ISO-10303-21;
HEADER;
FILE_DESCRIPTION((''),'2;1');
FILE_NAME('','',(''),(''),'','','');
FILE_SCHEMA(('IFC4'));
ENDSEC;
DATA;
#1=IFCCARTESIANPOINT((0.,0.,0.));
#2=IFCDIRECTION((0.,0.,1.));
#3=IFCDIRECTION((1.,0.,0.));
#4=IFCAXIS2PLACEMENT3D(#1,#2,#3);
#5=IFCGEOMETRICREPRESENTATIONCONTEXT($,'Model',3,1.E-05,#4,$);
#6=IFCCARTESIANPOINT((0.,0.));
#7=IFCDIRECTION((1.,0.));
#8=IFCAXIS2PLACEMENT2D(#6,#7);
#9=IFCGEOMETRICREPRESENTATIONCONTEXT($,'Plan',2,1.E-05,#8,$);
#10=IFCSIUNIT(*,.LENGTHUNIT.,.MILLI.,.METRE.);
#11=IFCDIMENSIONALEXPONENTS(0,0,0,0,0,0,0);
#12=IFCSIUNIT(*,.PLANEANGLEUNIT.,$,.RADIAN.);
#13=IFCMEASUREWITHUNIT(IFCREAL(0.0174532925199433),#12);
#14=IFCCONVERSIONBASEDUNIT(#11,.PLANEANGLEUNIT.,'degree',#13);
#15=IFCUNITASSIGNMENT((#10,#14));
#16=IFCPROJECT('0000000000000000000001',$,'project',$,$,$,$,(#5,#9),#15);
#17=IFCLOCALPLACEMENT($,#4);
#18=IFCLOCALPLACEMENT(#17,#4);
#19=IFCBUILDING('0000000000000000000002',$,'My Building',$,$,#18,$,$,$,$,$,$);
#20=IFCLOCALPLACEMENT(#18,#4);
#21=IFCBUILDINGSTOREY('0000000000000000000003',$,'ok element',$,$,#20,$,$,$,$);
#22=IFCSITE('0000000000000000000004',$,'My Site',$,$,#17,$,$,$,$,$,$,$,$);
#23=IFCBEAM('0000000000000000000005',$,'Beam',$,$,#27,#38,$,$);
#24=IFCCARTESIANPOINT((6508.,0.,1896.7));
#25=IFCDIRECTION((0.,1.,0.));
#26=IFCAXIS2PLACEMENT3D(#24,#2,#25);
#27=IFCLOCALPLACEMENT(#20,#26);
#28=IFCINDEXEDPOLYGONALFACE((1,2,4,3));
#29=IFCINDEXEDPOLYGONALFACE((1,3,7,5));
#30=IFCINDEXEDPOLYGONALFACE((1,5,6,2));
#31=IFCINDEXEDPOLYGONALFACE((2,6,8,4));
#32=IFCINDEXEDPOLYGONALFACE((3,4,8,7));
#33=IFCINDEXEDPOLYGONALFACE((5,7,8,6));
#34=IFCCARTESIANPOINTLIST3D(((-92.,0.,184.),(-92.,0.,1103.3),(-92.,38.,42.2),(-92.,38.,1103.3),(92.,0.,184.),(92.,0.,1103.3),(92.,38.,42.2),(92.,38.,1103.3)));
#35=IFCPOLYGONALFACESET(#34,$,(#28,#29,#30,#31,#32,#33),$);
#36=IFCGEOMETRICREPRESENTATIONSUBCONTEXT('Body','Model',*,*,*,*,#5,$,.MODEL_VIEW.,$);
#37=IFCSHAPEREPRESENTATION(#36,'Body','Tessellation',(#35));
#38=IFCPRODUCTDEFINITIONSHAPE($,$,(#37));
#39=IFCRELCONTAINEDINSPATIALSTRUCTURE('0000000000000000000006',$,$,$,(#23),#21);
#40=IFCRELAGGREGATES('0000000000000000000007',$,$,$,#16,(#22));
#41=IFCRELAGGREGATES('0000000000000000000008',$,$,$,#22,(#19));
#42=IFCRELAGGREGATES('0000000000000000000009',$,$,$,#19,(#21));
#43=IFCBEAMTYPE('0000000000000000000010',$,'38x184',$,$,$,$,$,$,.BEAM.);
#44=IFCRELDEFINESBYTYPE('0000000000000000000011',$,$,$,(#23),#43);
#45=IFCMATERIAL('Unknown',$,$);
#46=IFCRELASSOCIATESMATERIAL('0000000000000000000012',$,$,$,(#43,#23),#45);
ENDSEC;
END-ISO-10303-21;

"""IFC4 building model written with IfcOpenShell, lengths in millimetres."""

from ifc_helpers import new_model, entity, si_unit, converted_unit, frame, origin_with_axes, origin_2d_with_axis, place, context, subcontext, project, spatial, rectangle, extrude, clip, halfspace, material, material_profile, profile_set, profile_usage, type_object, element, save


model = new_model("IFC4")

# Units and contexts
model_context = context("Model", 3, precision=1e-05, world=origin_with_axes())
plan_context = context("Plan", 2, precision=1e-05, world=origin_2d_with_axis())
body_context = subcontext(model_context, "Body", "Model", "MODEL_VIEW")
ifc_project = project(units=[si_unit("LENGTHUNIT", "METRE", prefix="MILLI"), converted_unit("PLANEANGLEUNIT", "degree", entity("IfcReal", 0.0174532925199433), si_unit("PLANEANGLEUNIT", "RADIAN"), dimensions=[0, 0, 0, 0, 0, 0, 0])], contexts=[model_context, plan_context])

# Site, building, storey
site_placement = place(None, origin_with_axes())
site = spatial("IfcSite", under=ifc_project, at=site_placement, Name="My Site")
building_placement = place(site_placement, origin_with_axes())
building = spatial("IfcBuilding", under=site, at=building_placement, Name="My Building")
storey_placement = place(building_placement, origin_with_axes())
storey = spatial("IfcBuildingStorey", under=building, at=storey_placement, Name="ok element")

# Beam
ifc_material = material(Name="Unknown")
ifc_material_profile = material_profile(ifc_material, rectangle(XDim=184.0, YDim=38.0))
ifc_profile_set = profile_set([ifc_material_profile], Name="vurenhout")
beam_type = type_object("IfcBeamType", Name="38x184", PredefinedType="BEAM", material=ifc_profile_set)
ifc_profile_usage_1 = profile_usage(ifc_profile_set, cardinal=2)
beam_1_placement = place(storey_placement, frame((6508.0, 0.0, 1896.7), z_axis=(0.0, 0.0, 1.0), x_axis=(0.0, 1.0, 0.0)))
element("IfcBeam", 1, at=beam_1_placement, inside=storey, type_object=beam_type, material=ifc_profile_usage_1, Name="Beam", context=body_context, shape_type="Clipping", body=[
    clip(extrude(rectangle(XDim=184.0, YDim=38.0), frame((0.0, 19.0, 0.0), z_axis=(0.0, 0.0, 1.0), x_axis=(1.0, 0.0, 0.0)), (0.0, 0.0, 1.0), 1103.3), halfspace(frame((0.0, 592.3, -2026.6), z_axis=(0.0, -0.965926, -0.258819), x_axis=(0.0, -0.258819, 0.965926)), False)),
])

save(model, "model.ifc")
